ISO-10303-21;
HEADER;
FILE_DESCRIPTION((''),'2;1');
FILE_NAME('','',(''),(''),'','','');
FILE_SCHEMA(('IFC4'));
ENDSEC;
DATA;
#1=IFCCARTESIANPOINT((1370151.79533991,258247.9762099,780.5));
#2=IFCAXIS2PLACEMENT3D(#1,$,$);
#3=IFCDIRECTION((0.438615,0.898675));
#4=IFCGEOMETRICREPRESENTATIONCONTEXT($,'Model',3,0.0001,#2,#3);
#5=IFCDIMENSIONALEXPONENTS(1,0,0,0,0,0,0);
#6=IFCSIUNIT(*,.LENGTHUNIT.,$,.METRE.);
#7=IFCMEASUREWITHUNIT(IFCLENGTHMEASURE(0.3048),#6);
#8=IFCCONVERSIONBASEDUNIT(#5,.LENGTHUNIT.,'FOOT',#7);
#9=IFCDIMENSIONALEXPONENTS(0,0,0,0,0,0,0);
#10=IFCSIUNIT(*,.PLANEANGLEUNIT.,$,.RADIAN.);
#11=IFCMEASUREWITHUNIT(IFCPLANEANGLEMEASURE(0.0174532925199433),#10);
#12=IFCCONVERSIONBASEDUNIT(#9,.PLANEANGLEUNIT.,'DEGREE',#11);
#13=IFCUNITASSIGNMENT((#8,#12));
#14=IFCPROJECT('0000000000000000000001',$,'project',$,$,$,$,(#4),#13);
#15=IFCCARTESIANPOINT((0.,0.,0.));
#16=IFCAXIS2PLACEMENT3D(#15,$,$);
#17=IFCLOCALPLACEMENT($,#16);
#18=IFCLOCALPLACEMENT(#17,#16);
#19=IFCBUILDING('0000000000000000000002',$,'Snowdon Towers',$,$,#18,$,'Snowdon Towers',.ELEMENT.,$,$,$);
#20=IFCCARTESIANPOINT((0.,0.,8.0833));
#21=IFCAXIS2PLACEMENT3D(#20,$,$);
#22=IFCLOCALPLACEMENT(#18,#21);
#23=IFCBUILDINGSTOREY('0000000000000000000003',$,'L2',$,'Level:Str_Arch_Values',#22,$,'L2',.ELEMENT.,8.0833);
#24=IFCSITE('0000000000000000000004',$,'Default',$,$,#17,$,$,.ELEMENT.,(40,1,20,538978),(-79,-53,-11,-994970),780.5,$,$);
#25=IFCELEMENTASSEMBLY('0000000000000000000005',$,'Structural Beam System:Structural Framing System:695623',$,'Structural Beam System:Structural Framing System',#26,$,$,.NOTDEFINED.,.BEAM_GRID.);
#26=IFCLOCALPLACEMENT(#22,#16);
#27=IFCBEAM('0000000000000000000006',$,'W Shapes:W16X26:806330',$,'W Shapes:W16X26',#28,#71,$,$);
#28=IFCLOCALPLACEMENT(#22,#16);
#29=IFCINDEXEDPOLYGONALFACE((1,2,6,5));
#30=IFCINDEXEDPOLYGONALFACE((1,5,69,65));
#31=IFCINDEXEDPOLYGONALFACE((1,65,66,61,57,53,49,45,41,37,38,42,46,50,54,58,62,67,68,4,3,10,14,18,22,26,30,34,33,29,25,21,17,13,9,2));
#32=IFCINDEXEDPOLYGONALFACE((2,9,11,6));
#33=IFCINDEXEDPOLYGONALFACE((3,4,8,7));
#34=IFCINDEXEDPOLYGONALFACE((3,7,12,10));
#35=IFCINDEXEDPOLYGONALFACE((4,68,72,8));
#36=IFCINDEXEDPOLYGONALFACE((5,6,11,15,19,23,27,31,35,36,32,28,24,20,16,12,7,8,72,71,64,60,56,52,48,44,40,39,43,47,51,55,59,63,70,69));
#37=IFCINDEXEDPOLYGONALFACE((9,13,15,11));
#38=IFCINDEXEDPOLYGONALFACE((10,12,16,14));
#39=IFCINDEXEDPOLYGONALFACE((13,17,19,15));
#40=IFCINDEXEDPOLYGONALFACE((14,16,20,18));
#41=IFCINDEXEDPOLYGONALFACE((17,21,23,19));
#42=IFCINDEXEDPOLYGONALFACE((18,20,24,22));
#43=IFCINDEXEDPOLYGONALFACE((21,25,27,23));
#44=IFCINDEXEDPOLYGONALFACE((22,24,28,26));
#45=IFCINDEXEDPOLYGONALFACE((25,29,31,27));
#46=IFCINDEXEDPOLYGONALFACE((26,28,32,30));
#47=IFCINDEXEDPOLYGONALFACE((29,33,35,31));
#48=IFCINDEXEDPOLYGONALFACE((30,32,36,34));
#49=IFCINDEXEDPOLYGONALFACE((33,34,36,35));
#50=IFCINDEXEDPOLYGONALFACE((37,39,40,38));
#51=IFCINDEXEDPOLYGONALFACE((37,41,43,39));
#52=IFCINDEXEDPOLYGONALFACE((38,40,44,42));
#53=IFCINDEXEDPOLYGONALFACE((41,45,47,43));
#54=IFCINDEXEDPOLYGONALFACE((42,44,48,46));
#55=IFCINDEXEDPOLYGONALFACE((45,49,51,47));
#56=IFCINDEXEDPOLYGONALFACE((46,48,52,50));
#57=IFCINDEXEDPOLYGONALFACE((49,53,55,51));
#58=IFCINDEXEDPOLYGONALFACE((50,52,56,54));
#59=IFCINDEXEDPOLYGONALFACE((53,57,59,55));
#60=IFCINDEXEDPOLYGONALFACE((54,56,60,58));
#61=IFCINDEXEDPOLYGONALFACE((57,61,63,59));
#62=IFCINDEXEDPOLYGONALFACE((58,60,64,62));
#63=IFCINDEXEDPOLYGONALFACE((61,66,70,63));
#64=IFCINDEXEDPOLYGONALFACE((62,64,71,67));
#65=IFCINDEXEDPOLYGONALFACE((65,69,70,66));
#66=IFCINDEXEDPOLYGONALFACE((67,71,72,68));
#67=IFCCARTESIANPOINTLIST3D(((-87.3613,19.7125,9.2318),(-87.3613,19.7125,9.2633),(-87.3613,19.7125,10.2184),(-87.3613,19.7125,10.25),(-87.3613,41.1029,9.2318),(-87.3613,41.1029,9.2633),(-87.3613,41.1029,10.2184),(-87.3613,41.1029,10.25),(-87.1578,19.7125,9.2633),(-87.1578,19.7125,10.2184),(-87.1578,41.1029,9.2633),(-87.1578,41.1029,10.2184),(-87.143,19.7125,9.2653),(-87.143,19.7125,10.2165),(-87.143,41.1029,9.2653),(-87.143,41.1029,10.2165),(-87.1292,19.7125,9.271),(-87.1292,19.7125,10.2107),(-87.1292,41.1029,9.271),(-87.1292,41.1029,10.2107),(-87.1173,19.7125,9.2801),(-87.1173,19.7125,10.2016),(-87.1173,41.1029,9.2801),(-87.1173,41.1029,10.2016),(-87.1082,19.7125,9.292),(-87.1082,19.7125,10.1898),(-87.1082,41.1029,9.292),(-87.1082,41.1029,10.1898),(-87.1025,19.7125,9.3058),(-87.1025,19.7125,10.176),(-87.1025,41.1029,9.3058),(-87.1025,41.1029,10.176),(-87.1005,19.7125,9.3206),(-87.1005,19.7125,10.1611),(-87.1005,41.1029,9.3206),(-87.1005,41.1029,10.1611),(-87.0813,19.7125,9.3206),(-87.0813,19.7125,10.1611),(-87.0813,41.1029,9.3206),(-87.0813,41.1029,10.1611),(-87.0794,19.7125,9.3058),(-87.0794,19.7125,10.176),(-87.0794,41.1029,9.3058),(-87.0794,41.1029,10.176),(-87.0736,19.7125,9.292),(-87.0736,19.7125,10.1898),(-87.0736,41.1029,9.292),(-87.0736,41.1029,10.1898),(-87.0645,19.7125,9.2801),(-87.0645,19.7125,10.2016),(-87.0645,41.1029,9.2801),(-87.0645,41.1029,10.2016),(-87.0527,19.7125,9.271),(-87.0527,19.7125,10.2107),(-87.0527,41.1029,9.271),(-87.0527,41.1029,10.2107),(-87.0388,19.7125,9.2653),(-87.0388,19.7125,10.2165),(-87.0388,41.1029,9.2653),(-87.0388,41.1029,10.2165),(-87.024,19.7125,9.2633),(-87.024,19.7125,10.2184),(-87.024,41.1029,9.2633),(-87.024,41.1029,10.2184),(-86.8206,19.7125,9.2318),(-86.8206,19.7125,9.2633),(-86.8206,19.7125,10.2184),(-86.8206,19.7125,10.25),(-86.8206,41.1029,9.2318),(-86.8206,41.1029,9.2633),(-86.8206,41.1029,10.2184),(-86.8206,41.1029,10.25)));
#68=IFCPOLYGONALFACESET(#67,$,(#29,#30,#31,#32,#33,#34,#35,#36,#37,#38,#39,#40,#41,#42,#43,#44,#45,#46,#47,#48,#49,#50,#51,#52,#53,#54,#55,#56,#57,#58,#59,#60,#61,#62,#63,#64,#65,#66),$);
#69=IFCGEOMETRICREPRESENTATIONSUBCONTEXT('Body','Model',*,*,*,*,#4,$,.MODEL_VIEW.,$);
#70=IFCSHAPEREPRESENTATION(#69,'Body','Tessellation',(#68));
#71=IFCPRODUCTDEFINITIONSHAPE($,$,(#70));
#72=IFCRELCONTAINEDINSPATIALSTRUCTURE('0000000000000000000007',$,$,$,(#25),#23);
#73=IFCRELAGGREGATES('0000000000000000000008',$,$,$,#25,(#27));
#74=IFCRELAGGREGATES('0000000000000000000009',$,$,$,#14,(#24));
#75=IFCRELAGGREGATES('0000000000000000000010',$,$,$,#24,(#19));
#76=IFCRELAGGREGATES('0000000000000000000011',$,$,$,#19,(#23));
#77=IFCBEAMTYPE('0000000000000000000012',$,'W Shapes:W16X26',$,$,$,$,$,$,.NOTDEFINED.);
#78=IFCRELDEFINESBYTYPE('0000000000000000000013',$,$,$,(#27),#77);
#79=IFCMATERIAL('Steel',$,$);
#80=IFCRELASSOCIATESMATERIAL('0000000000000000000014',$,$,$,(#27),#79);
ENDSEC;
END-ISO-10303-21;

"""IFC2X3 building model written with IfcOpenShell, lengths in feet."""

from ifc_helpers import new_model, entity, si_unit, converted_unit, direction, frame, frame_2d, origin, place, context, subcontext, project, spatial, i_section, extrude, material, type_object, element, aggregate, save


model = new_model("IFC2X3")

# Units and contexts
model_context = context("Model", 3, precision=0.0001, world=frame((1370151.79533991, 258247.9762099, 780.5)), true_north=direction((0.438615, 0.898675)))
body_context = subcontext(model_context, "Body", "Model", "MODEL_VIEW")
ifc_project = project(units=[converted_unit("LENGTHUNIT", "FOOT", entity("IfcLengthMeasure", 0.3048), si_unit("LENGTHUNIT", "METRE"), dimensions=[1, 0, 0, 0, 0, 0, 0]), converted_unit("PLANEANGLEUNIT", "DEGREE", entity("IfcPlaneAngleMeasure", 0.0174532925199433), si_unit("PLANEANGLEUNIT", "RADIAN"), dimensions=[0, 0, 0, 0, 0, 0, 0])], contexts=[model_context])

# Site, building, storey
site_placement = place(None, origin())
site = spatial("IfcSite", under=ifc_project, at=site_placement, Name="Default", CompositionType="ELEMENT", RefLatitude=(40, 1, 20, 538978), RefLongitude=(-79, -53, -11, -994970), RefElevation=780.5)
building_placement = place(site_placement, origin())
building = spatial("IfcBuilding", under=site, at=building_placement, Name="Snowdon Towers", LongName="Snowdon Towers", CompositionType="ELEMENT")
storey_placement = place(building_placement, frame((0.0, 0.0, 8.0833)))
storey = spatial("IfcBuildingStorey", under=building, at=storey_placement, Name="L2", ObjectType="Level:Str_Arch_Values", LongName="L2", CompositionType="ELEMENT", Elevation=8.0833)

# Shared definitions
ifc_material = material(Name="Steel")

# Element assembly, beam
assembly_1_placement = place(storey_placement, origin())
assembly_1 = element("IfcElementAssembly", 1, at=assembly_1_placement, inside=storey, Name="Structural Beam System:Structural Framing System:695623", ObjectType="Structural Beam System:Structural Framing System", AssemblyPlace="NOTDEFINED", PredefinedType="BEAM_GRID")
beam_type_1 = type_object("IfcBeamType", Name="W Shapes:W16X26", PredefinedType="NOTDEFINED")
beam_1_placement = place(assembly_1_placement, frame((-87.0909, 41.4583, 10.25), z_axis=(0.0, 0.0, 1.0), x_axis=(0.0, -1.0, 0.0)))
beam_1 = element("IfcBeam", 2, at=beam_1_placement, type_object=beam_type_1, material=ifc_material, Name="W Shapes:W16X26:806330", ObjectType="W Shapes:W16X26", context=body_context, shape_type="SweptSolid", body=[
    extrude(i_section(OverallWidth=0.5407, OverallDepth=1.0182, WebThickness=0.0192, FlangeThickness=0.0316, FilletRadius=0.0573, at=frame_2d((0.0, 0.0), x_axis=(0.0, 1.0))), frame((0.3554, 0.0, -0.5091), z_axis=(1.0, 0.0, 0.0), x_axis=(0.0, 0.0, -1.0)), (0.0, 0.0, 1.0), 21.3904),
])
aggregate(assembly_1, [beam_1])

save(model, "model.ifc")
